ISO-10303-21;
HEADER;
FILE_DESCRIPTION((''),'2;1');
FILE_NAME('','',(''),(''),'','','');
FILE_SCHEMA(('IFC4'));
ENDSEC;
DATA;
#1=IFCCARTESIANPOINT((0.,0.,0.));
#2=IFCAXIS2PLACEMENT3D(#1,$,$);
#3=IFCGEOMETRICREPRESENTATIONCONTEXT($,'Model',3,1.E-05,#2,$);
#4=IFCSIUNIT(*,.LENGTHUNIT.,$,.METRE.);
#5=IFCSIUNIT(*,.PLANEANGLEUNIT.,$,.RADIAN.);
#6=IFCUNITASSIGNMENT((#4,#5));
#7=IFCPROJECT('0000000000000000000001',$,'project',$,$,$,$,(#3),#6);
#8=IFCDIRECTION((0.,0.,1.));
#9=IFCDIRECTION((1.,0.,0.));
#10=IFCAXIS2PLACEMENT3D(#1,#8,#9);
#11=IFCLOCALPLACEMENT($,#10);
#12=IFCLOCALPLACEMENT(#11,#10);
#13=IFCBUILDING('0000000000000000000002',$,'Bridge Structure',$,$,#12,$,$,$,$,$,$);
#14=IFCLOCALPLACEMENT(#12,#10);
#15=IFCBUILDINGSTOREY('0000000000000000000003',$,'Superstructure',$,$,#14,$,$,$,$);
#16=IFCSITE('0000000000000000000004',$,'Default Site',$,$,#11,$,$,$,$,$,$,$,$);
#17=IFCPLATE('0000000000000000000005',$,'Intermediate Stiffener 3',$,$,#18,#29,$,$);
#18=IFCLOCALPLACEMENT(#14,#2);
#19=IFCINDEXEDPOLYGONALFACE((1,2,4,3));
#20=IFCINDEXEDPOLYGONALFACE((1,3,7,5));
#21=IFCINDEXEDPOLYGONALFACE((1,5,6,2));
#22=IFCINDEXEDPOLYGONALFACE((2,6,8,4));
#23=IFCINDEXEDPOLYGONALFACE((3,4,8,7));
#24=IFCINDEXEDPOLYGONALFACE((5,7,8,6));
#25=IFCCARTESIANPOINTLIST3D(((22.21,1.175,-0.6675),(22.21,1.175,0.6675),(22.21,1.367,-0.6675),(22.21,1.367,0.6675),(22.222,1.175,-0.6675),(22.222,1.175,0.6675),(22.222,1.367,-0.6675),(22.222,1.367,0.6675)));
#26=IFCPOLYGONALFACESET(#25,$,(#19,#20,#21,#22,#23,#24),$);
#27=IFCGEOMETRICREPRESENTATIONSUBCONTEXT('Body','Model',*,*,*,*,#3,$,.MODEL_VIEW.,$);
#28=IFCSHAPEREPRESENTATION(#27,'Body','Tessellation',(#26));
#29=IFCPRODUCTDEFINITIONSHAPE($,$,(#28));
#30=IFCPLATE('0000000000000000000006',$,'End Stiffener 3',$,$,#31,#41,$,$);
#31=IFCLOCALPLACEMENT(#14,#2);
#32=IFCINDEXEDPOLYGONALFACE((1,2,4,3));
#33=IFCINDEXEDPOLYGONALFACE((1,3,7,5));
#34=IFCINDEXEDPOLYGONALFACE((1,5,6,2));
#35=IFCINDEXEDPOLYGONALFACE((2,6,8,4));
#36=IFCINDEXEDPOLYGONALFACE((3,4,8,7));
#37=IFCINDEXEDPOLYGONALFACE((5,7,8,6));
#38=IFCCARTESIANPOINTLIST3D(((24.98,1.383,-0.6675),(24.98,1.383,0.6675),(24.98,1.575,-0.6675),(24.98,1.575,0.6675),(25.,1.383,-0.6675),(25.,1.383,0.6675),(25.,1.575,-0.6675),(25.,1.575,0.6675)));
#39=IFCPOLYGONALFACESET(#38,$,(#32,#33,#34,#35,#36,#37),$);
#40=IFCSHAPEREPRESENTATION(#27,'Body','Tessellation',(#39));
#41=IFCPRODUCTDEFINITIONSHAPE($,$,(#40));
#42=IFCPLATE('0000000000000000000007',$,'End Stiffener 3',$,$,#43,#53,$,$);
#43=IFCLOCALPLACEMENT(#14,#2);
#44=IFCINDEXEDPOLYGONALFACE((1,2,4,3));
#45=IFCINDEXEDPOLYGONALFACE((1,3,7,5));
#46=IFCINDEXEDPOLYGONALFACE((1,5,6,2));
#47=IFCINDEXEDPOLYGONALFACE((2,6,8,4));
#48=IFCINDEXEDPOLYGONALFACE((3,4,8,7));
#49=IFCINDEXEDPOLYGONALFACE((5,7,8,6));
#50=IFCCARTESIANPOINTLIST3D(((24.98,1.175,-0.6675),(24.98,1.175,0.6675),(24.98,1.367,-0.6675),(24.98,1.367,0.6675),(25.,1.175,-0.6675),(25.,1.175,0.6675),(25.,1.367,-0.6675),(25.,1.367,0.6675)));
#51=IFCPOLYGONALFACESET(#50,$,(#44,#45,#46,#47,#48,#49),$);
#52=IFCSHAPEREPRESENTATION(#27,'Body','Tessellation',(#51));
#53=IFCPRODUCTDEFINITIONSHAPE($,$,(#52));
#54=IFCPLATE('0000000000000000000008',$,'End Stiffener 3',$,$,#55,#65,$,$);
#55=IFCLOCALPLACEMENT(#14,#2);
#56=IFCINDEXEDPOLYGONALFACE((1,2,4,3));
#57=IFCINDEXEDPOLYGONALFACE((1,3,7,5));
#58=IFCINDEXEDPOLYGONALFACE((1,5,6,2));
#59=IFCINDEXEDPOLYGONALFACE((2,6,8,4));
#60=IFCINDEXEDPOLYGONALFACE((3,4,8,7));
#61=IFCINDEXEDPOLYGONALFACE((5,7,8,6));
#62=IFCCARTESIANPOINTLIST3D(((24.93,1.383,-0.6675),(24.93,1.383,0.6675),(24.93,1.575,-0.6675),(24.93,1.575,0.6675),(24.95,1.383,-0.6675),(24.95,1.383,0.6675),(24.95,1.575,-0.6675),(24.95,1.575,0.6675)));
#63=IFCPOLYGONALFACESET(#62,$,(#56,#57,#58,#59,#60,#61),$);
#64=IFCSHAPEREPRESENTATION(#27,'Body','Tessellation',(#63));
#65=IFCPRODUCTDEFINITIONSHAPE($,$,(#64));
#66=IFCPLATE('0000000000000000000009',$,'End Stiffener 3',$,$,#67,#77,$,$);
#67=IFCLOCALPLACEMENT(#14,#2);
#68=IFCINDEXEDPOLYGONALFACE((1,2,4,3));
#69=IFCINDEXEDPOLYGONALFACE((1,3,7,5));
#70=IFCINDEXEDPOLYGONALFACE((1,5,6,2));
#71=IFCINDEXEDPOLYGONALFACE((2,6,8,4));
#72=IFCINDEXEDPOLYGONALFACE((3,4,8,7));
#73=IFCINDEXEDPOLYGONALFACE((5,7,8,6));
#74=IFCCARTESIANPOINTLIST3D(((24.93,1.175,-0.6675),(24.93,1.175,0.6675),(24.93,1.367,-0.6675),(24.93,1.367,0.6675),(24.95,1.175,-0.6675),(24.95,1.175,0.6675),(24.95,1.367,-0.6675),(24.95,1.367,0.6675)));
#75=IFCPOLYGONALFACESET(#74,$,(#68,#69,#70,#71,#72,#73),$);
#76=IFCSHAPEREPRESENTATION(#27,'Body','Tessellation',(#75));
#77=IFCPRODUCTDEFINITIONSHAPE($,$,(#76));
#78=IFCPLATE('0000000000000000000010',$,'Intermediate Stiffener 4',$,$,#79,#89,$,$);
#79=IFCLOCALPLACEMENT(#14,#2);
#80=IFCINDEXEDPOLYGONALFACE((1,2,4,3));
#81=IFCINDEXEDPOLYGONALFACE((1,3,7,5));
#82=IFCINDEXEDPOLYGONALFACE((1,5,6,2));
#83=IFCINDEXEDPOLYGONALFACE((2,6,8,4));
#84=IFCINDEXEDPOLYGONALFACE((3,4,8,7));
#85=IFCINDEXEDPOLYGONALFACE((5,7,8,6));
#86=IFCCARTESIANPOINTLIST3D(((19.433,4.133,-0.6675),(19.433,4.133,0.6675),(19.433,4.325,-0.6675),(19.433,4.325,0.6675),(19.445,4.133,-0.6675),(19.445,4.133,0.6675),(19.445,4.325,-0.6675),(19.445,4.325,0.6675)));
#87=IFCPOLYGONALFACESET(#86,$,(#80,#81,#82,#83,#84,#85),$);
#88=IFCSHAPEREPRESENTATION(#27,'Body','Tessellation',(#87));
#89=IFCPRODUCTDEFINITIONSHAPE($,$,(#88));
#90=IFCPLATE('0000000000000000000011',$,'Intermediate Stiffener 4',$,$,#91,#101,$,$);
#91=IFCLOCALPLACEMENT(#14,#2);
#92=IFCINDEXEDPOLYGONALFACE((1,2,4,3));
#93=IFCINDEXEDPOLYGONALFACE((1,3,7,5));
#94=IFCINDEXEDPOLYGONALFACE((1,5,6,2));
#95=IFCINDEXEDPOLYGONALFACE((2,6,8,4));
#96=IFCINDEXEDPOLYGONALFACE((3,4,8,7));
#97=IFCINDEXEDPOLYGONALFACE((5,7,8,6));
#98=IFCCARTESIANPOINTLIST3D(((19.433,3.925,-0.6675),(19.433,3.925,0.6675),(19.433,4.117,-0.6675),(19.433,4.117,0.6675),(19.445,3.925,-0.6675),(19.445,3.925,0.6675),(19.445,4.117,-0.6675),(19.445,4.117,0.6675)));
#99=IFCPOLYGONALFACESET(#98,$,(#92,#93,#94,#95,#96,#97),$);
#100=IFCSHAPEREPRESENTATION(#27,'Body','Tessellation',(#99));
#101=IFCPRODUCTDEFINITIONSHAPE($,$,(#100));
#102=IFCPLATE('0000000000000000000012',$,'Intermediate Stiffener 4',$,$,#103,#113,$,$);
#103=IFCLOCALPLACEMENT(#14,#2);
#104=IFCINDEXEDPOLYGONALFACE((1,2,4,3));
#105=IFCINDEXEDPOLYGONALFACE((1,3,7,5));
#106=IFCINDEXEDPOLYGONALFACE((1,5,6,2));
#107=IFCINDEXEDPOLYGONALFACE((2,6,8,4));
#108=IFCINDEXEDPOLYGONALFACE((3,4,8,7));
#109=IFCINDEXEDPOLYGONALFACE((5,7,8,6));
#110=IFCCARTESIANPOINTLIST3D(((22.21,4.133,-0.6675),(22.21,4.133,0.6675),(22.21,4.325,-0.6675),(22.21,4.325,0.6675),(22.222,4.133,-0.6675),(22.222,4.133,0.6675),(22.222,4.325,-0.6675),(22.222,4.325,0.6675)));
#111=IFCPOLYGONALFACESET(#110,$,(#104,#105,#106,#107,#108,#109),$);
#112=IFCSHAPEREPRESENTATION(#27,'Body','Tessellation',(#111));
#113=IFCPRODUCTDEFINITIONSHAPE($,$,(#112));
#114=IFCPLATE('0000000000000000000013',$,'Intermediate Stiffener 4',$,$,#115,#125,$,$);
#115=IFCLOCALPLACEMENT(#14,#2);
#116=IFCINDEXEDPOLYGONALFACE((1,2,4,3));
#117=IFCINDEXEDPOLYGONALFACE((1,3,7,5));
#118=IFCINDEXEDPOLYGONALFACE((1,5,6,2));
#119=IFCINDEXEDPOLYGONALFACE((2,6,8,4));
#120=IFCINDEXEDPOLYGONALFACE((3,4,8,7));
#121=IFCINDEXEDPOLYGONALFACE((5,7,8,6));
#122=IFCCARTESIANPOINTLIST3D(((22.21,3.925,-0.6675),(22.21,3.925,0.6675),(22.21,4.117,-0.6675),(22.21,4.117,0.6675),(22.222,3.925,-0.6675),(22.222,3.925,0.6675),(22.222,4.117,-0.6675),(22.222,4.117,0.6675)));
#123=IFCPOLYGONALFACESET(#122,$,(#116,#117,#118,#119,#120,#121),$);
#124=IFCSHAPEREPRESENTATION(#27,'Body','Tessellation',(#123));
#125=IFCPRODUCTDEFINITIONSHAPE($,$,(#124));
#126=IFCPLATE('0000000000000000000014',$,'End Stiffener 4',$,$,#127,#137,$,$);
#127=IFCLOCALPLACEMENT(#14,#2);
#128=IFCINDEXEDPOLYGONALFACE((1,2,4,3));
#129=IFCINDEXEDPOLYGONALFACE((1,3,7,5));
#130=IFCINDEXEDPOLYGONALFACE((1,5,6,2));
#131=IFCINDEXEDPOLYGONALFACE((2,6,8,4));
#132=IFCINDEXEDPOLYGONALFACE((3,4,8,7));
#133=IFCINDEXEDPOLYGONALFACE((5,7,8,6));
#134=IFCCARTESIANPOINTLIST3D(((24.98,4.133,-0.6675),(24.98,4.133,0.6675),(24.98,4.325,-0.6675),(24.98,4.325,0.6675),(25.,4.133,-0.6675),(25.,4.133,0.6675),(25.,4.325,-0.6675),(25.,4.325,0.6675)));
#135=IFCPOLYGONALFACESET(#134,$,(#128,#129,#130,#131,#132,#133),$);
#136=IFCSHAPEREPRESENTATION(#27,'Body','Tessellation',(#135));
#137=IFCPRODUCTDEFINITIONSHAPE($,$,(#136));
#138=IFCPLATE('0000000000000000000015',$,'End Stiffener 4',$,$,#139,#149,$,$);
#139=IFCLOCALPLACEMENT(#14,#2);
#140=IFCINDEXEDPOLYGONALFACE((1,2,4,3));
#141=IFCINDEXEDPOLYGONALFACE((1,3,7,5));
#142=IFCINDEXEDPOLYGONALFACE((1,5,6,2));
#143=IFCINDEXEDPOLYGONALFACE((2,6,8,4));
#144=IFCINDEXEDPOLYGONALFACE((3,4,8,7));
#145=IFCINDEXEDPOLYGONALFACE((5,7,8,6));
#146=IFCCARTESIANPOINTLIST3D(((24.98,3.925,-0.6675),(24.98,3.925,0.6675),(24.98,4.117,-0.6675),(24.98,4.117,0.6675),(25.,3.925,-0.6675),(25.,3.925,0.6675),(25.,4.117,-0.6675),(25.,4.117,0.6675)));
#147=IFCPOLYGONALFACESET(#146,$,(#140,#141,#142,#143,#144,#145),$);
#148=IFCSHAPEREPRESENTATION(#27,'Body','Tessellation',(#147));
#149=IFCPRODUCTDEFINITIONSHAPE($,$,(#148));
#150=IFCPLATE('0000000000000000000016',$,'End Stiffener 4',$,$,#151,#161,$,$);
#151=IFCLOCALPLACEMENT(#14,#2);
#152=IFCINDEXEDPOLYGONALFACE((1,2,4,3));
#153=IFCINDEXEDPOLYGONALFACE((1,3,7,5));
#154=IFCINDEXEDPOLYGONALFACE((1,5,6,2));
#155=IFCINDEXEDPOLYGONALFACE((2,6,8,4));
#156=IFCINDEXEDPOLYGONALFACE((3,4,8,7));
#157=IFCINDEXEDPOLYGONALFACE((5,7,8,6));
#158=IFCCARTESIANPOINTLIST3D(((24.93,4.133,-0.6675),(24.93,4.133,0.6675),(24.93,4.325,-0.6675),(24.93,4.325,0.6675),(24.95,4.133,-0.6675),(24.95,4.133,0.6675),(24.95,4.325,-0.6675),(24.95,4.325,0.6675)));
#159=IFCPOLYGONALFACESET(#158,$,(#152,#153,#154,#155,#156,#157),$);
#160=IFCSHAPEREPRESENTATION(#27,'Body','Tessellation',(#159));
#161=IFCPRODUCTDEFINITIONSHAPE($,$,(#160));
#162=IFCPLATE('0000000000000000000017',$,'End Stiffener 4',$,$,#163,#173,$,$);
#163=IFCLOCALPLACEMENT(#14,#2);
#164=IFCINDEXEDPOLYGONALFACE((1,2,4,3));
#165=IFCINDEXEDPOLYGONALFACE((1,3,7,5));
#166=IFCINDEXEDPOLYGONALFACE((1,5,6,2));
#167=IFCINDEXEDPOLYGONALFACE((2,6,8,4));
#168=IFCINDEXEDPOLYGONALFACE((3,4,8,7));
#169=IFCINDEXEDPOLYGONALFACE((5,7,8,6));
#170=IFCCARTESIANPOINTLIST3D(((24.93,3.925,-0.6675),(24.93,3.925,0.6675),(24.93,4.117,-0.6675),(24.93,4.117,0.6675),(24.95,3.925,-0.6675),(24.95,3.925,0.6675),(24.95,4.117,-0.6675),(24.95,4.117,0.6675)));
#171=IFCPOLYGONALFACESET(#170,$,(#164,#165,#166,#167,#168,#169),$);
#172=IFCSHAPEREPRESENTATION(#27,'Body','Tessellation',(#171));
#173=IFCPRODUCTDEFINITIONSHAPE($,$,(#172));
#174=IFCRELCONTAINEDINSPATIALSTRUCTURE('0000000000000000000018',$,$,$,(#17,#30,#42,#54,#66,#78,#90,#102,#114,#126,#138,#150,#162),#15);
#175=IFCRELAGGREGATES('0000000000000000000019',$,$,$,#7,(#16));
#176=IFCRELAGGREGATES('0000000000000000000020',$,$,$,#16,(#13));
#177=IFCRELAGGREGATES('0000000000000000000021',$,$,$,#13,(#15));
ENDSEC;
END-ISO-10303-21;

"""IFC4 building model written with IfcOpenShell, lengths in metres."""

from ifc_helpers import new_model, si_unit, frame, origin, origin_with_axes, origin_2d_with_axis, place, context, subcontext, project, spatial, rectangle, extrude, element, save


model = new_model("IFC4")

# Units and contexts
model_context = context("Model", 3, precision=1e-05, world=origin())
body_context = subcontext(model_context, "Body", "Model", "MODEL_VIEW")
ifc_project = project(units=[si_unit("LENGTHUNIT", "METRE"), si_unit("PLANEANGLEUNIT", "RADIAN")], contexts=[model_context])

# Site, building, storey
site_placement = place(None, origin_with_axes())
site = spatial("IfcSite", under=ifc_project, at=site_placement, Name="Default Site")
building_placement = place(site_placement, origin_with_axes())
building = spatial("IfcBuilding", under=site, at=building_placement, Name="Bridge Structure")
storey_placement = place(building_placement, origin_with_axes())
storey = spatial("IfcBuildingStorey", under=building, at=storey_placement, Name="Superstructure")

# Plates
for number, where, z_axis, x_axis, name in (
    (1, (22.216, 1.271, -0.6675), (0.0, 0.0, 1.0), (1.0, 0.0, 0.0), "Intermediate Stiffener 3"),
):
    element("IfcPlate", number, at=place(storey_placement, frame(where, z_axis=z_axis, x_axis=x_axis)), inside=storey, Name=name, context=body_context, shape_type="SweptSolid", body=[
        extrude(rectangle(XDim=0.012, YDim=0.192, at=origin_2d_with_axis()), origin_with_axes(), (0.0, 0.0, 1.0), 1.335),
    ])
for number, where, z_axis, x_axis, name in (
    (2, (24.99, 1.479, -0.6675), (0.0, 0.0, 1.0), (1.0, 0.0, 0.0), "End Stiffener 3"),
    (3, (24.99, 1.271, -0.6675), (0.0, 0.0, 1.0), (1.0, 0.0, 0.0), "End Stiffener 3"),
    (4, (24.94, 1.479, -0.6675), (0.0, 0.0, 1.0), (1.0, 0.0, 0.0), "End Stiffener 3"),
    (5, (24.94, 1.271, -0.6675), (0.0, 0.0, 1.0), (1.0, 0.0, 0.0), "End Stiffener 3"),
):
    element("IfcPlate", number, at=place(storey_placement, frame(where, z_axis=z_axis, x_axis=x_axis)), inside=storey, Name=name, context=body_context, shape_type="SweptSolid", body=[
        extrude(rectangle(XDim=0.02, YDim=0.192, at=origin_2d_with_axis()), origin_with_axes(), (0.0, 0.0, 1.0), 1.335),
    ])
for number, where, z_axis, x_axis, name in (
    (6, (19.439, 4.229, -0.6675), (0.0, 0.0, 1.0), (1.0, 0.0, 0.0), "Intermediate Stiffener 4"),
    (7, (19.439, 4.021, -0.6675), (0.0, 0.0, 1.0), (1.0, 0.0, 0.0), "Intermediate Stiffener 4"),
    (8, (22.216, 4.229, -0.6675), (0.0, 0.0, 1.0), (1.0, 0.0, 0.0), "Intermediate Stiffener 4"),
    (9, (22.216, 4.021, -0.6675), (0.0, 0.0, 1.0), (1.0, 0.0, 0.0), "Intermediate Stiffener 4"),
):
    element("IfcPlate", number, at=place(storey_placement, frame(where, z_axis=z_axis, x_axis=x_axis)), inside=storey, Name=name, context=body_context, shape_type="SweptSolid", body=[
        extrude(rectangle(XDim=0.012, YDim=0.192, at=origin_2d_with_axis()), origin_with_axes(), (0.0, 0.0, 1.0), 1.335),
    ])
for number, where, z_axis, x_axis, name in (
    (10, (24.99, 4.229, -0.6675), (0.0, 0.0, 1.0), (1.0, 0.0, 0.0), "End Stiffener 4"),
    (11, (24.99, 4.021, -0.6675), (0.0, 0.0, 1.0), (1.0, 0.0, 0.0), "End Stiffener 4"),
    (12, (24.94, 4.229, -0.6675), (0.0, 0.0, 1.0), (1.0, 0.0, 0.0), "End Stiffener 4"),
    (13, (24.94, 4.021, -0.6675), (0.0, 0.0, 1.0), (1.0, 0.0, 0.0), "End Stiffener 4"),
):
    element("IfcPlate", number, at=place(storey_placement, frame(where, z_axis=z_axis, x_axis=x_axis)), inside=storey, Name=name, context=body_context, shape_type="SweptSolid", body=[
        extrude(rectangle(XDim=0.02, YDim=0.192, at=origin_2d_with_axis()), origin_with_axes(), (0.0, 0.0, 1.0), 1.335),
    ])

save(model, "model.ifc")
